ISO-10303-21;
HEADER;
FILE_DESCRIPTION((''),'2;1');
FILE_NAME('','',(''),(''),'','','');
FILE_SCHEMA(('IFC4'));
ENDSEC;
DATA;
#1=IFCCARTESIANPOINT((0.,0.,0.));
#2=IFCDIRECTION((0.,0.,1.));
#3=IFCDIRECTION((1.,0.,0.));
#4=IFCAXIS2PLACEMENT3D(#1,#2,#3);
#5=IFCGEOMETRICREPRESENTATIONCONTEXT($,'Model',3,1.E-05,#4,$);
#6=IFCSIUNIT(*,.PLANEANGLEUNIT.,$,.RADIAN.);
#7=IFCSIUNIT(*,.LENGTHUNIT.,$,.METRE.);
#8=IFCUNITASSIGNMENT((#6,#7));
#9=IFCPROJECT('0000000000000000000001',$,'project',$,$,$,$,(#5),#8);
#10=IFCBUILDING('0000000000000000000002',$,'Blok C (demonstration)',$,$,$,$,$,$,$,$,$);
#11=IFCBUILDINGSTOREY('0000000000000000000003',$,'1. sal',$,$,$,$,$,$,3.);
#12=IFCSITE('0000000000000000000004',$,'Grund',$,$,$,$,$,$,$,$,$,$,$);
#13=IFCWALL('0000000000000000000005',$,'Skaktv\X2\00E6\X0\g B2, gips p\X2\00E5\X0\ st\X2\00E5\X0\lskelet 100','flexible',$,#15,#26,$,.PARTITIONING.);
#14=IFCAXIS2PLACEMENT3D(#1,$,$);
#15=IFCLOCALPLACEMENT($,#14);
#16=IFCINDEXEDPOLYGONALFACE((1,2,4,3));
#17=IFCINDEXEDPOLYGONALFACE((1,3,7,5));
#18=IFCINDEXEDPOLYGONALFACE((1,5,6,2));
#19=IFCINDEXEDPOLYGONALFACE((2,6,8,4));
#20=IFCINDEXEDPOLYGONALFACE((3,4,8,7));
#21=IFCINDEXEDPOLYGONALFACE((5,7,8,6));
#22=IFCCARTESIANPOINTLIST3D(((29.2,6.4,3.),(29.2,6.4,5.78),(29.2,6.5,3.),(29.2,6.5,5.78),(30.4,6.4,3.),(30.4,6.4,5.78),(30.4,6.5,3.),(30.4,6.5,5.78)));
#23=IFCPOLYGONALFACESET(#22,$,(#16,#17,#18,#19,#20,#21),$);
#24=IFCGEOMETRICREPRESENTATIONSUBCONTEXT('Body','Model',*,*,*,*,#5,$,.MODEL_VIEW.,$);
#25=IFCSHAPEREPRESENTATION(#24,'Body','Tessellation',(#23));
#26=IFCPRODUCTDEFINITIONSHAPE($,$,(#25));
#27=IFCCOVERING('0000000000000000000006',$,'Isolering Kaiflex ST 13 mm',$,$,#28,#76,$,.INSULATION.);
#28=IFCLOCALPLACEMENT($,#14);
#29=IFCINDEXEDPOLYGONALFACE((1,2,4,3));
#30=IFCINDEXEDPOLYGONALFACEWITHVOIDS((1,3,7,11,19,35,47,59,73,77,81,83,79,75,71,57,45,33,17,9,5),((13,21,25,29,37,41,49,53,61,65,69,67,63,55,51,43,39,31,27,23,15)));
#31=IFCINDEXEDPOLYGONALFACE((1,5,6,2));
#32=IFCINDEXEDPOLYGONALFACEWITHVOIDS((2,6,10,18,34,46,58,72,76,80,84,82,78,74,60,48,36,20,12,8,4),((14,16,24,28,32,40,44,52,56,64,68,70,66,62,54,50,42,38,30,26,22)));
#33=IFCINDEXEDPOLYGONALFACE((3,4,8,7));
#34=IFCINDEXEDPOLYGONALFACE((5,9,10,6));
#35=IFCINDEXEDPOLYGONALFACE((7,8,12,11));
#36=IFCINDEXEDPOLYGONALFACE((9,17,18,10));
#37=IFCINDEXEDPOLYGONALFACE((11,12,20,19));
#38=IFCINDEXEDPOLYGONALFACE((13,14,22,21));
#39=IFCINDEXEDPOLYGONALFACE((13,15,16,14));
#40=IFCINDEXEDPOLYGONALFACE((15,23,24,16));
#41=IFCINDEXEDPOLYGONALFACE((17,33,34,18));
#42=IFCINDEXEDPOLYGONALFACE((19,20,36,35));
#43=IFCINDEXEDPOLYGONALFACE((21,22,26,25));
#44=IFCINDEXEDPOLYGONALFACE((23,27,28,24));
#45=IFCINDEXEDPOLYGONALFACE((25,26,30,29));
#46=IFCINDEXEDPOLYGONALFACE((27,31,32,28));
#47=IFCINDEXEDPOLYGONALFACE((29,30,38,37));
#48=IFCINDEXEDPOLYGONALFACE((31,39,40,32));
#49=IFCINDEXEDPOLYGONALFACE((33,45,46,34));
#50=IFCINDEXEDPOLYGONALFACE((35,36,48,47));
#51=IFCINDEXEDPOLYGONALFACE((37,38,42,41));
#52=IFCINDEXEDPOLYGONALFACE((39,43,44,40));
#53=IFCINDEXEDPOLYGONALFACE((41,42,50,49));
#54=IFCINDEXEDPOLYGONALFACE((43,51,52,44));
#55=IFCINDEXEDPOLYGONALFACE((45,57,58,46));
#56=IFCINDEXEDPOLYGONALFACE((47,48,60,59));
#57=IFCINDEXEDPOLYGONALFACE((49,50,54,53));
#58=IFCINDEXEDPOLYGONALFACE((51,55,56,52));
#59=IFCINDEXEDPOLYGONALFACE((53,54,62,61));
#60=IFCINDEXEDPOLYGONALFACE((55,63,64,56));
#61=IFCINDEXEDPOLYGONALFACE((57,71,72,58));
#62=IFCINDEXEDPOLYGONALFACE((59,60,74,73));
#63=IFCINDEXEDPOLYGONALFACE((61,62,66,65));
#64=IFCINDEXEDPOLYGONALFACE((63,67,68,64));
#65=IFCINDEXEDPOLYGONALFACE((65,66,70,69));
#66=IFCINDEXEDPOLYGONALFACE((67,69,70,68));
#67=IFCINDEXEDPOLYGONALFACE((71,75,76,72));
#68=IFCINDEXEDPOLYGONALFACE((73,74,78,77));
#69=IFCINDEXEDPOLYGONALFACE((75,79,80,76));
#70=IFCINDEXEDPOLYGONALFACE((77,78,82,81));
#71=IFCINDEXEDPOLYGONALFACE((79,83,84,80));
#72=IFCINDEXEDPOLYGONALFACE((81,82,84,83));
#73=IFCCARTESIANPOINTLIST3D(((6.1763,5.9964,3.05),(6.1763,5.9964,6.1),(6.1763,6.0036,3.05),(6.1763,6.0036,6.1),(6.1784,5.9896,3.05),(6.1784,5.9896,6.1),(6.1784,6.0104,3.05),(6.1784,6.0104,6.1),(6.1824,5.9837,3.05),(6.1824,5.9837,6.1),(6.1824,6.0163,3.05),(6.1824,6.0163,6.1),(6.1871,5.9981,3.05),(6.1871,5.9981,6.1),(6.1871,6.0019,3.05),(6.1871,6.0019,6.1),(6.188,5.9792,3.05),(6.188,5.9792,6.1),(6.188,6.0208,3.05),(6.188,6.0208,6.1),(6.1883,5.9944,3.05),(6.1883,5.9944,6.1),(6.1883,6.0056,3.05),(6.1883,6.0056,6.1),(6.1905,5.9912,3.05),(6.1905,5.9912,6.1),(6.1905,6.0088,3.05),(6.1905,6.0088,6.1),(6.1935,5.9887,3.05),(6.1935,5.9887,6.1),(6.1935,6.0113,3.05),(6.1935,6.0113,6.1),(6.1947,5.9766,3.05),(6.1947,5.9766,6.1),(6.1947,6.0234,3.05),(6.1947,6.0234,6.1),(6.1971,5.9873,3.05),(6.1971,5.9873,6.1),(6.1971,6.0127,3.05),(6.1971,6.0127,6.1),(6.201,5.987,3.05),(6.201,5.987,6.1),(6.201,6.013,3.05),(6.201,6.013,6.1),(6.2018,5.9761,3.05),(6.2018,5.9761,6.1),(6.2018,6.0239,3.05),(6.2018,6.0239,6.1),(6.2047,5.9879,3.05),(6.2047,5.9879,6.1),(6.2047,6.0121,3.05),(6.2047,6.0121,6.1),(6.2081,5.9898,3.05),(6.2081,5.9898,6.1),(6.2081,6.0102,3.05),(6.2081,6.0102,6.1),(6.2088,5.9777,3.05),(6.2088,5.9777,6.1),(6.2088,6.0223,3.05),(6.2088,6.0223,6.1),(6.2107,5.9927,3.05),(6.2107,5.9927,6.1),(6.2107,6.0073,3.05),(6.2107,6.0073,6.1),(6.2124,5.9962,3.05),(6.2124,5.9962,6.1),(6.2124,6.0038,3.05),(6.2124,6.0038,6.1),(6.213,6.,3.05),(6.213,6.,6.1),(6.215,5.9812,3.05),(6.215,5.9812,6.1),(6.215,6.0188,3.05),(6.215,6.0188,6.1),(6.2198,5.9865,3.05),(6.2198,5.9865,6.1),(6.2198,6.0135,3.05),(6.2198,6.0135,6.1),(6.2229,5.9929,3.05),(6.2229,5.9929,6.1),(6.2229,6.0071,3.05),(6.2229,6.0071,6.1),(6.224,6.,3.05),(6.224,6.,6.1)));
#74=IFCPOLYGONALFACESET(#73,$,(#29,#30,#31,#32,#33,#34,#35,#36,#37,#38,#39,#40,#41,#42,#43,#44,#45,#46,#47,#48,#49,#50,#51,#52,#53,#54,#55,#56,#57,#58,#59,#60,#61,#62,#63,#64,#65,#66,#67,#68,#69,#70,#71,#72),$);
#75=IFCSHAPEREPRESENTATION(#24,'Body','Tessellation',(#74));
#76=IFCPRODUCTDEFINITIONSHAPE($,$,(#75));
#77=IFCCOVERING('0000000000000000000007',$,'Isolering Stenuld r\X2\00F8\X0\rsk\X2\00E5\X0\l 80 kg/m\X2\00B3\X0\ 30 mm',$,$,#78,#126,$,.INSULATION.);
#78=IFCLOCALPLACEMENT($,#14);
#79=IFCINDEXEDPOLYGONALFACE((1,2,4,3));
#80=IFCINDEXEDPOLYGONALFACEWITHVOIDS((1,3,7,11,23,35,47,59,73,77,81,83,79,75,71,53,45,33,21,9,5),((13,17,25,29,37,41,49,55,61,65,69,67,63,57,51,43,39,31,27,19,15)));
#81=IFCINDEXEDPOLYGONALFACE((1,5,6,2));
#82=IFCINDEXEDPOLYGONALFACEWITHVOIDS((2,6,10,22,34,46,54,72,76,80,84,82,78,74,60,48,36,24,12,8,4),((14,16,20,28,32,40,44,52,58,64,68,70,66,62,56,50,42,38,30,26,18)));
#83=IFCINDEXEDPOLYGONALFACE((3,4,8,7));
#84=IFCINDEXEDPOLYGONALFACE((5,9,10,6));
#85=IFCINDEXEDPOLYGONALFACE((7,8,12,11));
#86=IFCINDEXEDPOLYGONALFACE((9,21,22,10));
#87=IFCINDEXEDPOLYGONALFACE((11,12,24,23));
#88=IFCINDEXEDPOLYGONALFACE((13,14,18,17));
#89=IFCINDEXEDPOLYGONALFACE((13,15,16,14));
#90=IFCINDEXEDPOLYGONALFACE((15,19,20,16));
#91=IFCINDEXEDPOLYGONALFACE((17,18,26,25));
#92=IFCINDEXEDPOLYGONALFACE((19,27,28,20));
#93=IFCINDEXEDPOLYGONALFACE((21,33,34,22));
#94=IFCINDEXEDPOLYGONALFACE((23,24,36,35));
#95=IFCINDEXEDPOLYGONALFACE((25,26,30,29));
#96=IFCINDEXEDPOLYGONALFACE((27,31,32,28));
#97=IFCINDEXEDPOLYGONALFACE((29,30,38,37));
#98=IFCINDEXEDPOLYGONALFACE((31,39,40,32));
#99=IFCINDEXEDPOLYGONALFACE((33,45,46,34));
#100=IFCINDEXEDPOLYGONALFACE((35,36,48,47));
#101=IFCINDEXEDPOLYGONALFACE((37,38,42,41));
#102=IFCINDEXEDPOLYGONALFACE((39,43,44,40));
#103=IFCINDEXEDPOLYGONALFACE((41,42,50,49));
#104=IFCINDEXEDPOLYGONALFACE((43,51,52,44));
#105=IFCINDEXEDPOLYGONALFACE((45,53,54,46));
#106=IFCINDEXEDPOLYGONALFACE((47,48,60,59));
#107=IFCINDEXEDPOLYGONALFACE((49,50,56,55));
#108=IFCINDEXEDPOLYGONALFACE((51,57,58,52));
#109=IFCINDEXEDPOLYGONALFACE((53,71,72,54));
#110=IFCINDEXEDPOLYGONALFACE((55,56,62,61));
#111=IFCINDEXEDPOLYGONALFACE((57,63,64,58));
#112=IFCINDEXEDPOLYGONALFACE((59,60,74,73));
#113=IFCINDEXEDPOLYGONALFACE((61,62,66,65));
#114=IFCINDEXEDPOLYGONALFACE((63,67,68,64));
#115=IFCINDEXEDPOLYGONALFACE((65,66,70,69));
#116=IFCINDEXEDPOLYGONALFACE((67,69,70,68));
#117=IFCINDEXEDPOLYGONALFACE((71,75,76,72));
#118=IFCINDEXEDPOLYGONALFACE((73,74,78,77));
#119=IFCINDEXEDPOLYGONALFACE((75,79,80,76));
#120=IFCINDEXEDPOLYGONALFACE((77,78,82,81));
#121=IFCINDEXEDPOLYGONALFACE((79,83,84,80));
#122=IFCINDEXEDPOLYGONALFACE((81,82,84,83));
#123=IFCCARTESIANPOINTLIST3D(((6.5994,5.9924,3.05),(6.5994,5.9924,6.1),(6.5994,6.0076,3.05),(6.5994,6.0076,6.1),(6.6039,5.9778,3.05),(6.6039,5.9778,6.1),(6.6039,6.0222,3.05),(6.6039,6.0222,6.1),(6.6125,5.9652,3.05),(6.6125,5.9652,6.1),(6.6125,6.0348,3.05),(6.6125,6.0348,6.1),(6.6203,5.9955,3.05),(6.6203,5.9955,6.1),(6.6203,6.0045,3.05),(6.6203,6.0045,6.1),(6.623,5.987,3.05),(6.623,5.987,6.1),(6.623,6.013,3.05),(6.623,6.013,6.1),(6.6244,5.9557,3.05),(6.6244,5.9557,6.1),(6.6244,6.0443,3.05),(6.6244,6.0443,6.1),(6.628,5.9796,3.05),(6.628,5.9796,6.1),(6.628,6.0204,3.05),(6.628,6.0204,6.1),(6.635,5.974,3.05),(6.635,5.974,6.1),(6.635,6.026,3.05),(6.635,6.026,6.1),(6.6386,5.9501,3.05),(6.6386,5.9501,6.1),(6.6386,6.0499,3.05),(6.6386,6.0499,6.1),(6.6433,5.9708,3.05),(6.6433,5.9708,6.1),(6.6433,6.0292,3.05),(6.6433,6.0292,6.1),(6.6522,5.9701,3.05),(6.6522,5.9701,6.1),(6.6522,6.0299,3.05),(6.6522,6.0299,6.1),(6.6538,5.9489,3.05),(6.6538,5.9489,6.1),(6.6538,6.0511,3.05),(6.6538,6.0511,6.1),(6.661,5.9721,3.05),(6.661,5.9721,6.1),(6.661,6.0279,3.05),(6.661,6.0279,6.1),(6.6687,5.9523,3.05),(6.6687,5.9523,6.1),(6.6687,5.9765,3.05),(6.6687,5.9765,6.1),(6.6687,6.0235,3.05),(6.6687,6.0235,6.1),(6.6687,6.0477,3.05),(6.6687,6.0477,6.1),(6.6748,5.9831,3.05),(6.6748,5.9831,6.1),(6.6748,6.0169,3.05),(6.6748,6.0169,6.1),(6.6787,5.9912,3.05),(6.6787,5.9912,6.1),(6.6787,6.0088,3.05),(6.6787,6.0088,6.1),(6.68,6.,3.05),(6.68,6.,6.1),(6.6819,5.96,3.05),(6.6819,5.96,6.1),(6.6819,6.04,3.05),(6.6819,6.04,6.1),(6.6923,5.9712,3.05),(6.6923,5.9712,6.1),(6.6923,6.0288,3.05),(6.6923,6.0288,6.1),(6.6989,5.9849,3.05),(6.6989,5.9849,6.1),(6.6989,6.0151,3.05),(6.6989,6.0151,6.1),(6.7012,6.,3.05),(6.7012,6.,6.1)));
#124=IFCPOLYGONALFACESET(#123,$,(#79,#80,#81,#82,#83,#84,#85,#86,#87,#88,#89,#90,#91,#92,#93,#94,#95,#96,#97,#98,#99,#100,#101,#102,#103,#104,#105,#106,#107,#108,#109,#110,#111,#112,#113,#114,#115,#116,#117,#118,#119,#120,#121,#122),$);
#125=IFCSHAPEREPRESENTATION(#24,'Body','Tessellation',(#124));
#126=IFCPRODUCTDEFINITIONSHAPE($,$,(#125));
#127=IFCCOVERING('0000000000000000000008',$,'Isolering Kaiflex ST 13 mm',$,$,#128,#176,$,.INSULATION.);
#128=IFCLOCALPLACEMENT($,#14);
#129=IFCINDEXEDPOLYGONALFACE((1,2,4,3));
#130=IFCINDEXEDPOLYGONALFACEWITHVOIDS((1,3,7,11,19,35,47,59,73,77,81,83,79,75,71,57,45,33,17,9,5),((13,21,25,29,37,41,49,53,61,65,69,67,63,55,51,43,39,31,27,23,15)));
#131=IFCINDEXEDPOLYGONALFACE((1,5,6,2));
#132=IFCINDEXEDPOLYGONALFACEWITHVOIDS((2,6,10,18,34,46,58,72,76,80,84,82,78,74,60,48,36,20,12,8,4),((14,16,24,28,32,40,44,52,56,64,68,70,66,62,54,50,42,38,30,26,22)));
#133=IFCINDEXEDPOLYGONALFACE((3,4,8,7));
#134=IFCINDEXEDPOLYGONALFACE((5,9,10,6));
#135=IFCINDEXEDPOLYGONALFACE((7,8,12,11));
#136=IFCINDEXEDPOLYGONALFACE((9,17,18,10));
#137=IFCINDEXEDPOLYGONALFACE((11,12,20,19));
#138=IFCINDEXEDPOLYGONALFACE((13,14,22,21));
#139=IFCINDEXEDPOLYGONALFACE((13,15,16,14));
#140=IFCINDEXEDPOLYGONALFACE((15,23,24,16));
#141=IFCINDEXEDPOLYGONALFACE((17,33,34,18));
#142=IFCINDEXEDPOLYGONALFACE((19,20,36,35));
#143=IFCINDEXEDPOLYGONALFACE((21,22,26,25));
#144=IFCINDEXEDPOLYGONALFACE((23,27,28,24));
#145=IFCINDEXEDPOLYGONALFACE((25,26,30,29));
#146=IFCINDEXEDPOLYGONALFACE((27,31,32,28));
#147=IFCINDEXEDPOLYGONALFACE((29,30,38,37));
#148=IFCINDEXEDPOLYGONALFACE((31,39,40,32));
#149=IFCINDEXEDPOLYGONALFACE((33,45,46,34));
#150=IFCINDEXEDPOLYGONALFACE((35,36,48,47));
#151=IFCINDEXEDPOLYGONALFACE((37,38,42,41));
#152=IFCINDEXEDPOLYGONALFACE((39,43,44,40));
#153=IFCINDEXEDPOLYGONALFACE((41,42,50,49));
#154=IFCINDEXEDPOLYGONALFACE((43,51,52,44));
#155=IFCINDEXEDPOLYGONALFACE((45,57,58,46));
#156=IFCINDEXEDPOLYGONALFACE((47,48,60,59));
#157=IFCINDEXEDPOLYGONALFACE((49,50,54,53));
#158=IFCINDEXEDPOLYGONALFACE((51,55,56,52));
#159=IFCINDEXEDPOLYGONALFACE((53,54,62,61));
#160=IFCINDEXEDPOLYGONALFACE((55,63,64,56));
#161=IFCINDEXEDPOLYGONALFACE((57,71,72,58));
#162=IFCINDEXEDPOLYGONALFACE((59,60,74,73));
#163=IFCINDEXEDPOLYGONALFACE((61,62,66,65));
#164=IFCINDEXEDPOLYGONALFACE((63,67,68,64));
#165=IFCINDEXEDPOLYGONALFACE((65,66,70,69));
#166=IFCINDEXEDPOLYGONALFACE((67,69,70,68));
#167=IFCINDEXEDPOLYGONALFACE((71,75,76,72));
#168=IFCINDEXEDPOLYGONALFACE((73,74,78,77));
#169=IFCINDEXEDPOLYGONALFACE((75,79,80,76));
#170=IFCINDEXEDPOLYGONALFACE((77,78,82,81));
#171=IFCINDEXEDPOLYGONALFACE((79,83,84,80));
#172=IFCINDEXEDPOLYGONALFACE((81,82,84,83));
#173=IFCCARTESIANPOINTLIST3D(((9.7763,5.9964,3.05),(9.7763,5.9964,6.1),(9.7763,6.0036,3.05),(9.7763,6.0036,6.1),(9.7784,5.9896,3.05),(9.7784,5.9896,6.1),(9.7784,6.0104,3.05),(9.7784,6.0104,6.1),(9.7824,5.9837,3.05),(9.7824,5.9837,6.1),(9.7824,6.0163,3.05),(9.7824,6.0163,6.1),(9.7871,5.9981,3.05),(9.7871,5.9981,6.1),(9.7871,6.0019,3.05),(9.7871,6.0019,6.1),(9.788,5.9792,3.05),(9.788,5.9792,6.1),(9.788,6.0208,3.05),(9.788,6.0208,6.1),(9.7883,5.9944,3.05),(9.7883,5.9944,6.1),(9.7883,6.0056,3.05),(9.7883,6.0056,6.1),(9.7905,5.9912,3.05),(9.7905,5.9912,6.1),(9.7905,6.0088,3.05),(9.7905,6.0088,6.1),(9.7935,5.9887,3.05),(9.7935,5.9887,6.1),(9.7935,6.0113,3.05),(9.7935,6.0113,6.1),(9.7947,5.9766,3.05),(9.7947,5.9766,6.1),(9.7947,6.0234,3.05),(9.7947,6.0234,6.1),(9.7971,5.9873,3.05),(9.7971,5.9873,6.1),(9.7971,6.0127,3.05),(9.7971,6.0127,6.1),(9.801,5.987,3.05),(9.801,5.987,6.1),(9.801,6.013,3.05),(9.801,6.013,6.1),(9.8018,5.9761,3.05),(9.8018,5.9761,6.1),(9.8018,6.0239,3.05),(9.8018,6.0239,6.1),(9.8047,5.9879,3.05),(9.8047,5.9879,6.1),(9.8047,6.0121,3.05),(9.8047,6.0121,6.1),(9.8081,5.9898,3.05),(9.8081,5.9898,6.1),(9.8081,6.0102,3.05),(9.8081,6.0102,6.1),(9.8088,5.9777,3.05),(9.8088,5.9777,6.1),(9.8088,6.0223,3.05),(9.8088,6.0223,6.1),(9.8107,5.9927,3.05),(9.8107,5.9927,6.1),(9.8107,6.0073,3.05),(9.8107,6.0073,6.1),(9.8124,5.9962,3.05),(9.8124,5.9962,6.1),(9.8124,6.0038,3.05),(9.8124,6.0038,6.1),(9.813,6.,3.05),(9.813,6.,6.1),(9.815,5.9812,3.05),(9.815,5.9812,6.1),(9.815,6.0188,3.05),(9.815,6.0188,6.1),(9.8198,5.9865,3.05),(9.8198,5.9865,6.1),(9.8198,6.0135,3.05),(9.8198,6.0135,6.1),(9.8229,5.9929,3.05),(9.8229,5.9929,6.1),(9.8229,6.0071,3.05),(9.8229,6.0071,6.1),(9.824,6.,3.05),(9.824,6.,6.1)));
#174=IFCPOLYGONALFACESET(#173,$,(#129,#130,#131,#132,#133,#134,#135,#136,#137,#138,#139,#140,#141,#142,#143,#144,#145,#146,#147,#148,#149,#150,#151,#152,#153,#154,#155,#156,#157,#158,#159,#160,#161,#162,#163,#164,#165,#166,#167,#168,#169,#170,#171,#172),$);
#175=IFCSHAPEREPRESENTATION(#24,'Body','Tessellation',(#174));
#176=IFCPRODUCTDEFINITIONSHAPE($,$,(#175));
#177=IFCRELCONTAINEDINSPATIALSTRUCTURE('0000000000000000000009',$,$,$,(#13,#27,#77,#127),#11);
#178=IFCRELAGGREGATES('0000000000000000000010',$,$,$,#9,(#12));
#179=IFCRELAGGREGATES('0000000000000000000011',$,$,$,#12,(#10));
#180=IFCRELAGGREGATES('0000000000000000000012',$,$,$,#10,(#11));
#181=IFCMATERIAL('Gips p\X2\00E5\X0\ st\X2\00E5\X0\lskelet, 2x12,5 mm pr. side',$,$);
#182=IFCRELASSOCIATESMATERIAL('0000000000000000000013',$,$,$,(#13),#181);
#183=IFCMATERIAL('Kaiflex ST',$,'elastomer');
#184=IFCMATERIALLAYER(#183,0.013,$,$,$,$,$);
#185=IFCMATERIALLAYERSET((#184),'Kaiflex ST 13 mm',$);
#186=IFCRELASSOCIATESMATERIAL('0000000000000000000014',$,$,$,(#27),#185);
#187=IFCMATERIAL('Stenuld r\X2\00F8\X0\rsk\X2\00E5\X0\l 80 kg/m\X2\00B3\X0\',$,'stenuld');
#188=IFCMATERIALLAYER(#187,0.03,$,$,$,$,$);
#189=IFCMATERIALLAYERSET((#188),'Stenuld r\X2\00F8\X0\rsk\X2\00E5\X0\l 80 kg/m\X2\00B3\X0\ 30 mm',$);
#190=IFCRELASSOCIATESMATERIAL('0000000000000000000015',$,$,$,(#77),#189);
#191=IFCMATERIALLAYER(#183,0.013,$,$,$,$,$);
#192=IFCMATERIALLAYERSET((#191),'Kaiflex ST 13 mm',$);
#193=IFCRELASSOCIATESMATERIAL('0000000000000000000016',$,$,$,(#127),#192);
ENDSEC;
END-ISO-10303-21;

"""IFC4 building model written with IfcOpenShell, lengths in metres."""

from ifc_helpers import new_model, si_unit, frame, origin_with_axes, place, context, subcontext, project, spatial, polyline, hollow_circle, outline, extrude, material, layer, layer_set, element, save


model = new_model("IFC4")

# Units and contexts
model_context = context("Model", 3, precision=1e-05, world=origin_with_axes())
body_context = subcontext(model_context, "Body", "Model", "MODEL_VIEW")
ifc_project = project(units=[si_unit("PLANEANGLEUNIT", "RADIAN"), si_unit("LENGTHUNIT", "METRE")], contexts=[model_context])

# Site, building, storey
site = spatial("IfcSite", under=ifc_project, Name="Grund")
building = spatial("IfcBuilding", under=site, Name="Blok C (demonstration)")
storey = spatial("IfcBuildingStorey", under=building, Name="1. sal", Elevation=3.0)

# Shared definitions
ifc_material_1 = material(Name="Gips på stålskelet, 2x12,5 mm pr. side")

# Wall
wall_1_placement = place(None, origin_with_axes())
element("IfcWall", 1, at=wall_1_placement, inside=storey, material=ifc_material_1, Name="Skaktvæg B2, gips på stålskelet 100", Description="flexible", PredefinedType="PARTITIONING", context=body_context, shape_type="SweptSolid", body=[
    extrude(outline(polyline([(29.2, 6.4), (30.4, 6.4), (30.4, 6.5), (29.2, 6.5), (29.2, 6.4)])), frame((0.0, 0.0, 3.0)), (0.0, 0.0, 1.0), 2.78),
])

# Coverings
ifc_material_2 = material(Name="Kaiflex ST", Category="elastomer")
ifc_layer_1 = layer(ifc_material_2, 0.013)
ifc_layer_set_1 = layer_set([ifc_layer_1], Name="Kaiflex ST 13 mm")
covering_1_placement = place(None, origin_with_axes())
element("IfcCovering", 2, at=covering_1_placement, inside=storey, material=ifc_layer_set_1, Name="Isolering Kaiflex ST 13 mm", PredefinedType="INSULATION", context=body_context, shape_type="SweptSolid", body=[
    extrude(hollow_circle(Radius=0.024, WallThickness=0.011), frame((6.2, 6.0, 3.05), z_axis=(0.0, 0.0, 1.0), x_axis=(1.0, 0.0, 0.0)), (0.0, 0.0, 1.0), 3.05),
])
ifc_material_3 = material(Name="Stenuld rørskål 80 kg/m³", Category="stenuld")
ifc_layer_2 = layer(ifc_material_3, 0.03)
ifc_layer_set_2 = layer_set([ifc_layer_2], Name="Stenuld rørskål 80 kg/m³ 30 mm")
covering_2_placement = place(None, origin_with_axes())
element("IfcCovering", 3, at=covering_2_placement, inside=storey, material=ifc_layer_set_2, Name="Isolering Stenuld rørskål 80 kg/m³ 30 mm", PredefinedType="INSULATION", context=body_context, shape_type="SweptSolid", body=[
    extrude(hollow_circle(Radius=0.0512, WallThickness=0.0212), frame((6.65, 6.0, 3.05), z_axis=(0.0, 0.0, 1.0), x_axis=(1.0, 0.0, 0.0)), (0.0, 0.0, 1.0), 3.05),
])
ifc_layer_3 = layer(ifc_material_2, 0.013)
ifc_layer_set_3 = layer_set([ifc_layer_3], Name="Kaiflex ST 13 mm")
covering_3_placement = place(None, origin_with_axes())
element("IfcCovering", 4, at=covering_3_placement, inside=storey, material=ifc_layer_set_3, Name="Isolering Kaiflex ST 13 mm", PredefinedType="INSULATION", context=body_context, shape_type="SweptSolid", body=[
    extrude(hollow_circle(Radius=0.024, WallThickness=0.011), frame((9.8, 6.0, 3.05), z_axis=(0.0, 0.0, 1.0), x_axis=(1.0, 0.0, 0.0)), (0.0, 0.0, 1.0), 3.05),
])

save(model, "model.ifc")
